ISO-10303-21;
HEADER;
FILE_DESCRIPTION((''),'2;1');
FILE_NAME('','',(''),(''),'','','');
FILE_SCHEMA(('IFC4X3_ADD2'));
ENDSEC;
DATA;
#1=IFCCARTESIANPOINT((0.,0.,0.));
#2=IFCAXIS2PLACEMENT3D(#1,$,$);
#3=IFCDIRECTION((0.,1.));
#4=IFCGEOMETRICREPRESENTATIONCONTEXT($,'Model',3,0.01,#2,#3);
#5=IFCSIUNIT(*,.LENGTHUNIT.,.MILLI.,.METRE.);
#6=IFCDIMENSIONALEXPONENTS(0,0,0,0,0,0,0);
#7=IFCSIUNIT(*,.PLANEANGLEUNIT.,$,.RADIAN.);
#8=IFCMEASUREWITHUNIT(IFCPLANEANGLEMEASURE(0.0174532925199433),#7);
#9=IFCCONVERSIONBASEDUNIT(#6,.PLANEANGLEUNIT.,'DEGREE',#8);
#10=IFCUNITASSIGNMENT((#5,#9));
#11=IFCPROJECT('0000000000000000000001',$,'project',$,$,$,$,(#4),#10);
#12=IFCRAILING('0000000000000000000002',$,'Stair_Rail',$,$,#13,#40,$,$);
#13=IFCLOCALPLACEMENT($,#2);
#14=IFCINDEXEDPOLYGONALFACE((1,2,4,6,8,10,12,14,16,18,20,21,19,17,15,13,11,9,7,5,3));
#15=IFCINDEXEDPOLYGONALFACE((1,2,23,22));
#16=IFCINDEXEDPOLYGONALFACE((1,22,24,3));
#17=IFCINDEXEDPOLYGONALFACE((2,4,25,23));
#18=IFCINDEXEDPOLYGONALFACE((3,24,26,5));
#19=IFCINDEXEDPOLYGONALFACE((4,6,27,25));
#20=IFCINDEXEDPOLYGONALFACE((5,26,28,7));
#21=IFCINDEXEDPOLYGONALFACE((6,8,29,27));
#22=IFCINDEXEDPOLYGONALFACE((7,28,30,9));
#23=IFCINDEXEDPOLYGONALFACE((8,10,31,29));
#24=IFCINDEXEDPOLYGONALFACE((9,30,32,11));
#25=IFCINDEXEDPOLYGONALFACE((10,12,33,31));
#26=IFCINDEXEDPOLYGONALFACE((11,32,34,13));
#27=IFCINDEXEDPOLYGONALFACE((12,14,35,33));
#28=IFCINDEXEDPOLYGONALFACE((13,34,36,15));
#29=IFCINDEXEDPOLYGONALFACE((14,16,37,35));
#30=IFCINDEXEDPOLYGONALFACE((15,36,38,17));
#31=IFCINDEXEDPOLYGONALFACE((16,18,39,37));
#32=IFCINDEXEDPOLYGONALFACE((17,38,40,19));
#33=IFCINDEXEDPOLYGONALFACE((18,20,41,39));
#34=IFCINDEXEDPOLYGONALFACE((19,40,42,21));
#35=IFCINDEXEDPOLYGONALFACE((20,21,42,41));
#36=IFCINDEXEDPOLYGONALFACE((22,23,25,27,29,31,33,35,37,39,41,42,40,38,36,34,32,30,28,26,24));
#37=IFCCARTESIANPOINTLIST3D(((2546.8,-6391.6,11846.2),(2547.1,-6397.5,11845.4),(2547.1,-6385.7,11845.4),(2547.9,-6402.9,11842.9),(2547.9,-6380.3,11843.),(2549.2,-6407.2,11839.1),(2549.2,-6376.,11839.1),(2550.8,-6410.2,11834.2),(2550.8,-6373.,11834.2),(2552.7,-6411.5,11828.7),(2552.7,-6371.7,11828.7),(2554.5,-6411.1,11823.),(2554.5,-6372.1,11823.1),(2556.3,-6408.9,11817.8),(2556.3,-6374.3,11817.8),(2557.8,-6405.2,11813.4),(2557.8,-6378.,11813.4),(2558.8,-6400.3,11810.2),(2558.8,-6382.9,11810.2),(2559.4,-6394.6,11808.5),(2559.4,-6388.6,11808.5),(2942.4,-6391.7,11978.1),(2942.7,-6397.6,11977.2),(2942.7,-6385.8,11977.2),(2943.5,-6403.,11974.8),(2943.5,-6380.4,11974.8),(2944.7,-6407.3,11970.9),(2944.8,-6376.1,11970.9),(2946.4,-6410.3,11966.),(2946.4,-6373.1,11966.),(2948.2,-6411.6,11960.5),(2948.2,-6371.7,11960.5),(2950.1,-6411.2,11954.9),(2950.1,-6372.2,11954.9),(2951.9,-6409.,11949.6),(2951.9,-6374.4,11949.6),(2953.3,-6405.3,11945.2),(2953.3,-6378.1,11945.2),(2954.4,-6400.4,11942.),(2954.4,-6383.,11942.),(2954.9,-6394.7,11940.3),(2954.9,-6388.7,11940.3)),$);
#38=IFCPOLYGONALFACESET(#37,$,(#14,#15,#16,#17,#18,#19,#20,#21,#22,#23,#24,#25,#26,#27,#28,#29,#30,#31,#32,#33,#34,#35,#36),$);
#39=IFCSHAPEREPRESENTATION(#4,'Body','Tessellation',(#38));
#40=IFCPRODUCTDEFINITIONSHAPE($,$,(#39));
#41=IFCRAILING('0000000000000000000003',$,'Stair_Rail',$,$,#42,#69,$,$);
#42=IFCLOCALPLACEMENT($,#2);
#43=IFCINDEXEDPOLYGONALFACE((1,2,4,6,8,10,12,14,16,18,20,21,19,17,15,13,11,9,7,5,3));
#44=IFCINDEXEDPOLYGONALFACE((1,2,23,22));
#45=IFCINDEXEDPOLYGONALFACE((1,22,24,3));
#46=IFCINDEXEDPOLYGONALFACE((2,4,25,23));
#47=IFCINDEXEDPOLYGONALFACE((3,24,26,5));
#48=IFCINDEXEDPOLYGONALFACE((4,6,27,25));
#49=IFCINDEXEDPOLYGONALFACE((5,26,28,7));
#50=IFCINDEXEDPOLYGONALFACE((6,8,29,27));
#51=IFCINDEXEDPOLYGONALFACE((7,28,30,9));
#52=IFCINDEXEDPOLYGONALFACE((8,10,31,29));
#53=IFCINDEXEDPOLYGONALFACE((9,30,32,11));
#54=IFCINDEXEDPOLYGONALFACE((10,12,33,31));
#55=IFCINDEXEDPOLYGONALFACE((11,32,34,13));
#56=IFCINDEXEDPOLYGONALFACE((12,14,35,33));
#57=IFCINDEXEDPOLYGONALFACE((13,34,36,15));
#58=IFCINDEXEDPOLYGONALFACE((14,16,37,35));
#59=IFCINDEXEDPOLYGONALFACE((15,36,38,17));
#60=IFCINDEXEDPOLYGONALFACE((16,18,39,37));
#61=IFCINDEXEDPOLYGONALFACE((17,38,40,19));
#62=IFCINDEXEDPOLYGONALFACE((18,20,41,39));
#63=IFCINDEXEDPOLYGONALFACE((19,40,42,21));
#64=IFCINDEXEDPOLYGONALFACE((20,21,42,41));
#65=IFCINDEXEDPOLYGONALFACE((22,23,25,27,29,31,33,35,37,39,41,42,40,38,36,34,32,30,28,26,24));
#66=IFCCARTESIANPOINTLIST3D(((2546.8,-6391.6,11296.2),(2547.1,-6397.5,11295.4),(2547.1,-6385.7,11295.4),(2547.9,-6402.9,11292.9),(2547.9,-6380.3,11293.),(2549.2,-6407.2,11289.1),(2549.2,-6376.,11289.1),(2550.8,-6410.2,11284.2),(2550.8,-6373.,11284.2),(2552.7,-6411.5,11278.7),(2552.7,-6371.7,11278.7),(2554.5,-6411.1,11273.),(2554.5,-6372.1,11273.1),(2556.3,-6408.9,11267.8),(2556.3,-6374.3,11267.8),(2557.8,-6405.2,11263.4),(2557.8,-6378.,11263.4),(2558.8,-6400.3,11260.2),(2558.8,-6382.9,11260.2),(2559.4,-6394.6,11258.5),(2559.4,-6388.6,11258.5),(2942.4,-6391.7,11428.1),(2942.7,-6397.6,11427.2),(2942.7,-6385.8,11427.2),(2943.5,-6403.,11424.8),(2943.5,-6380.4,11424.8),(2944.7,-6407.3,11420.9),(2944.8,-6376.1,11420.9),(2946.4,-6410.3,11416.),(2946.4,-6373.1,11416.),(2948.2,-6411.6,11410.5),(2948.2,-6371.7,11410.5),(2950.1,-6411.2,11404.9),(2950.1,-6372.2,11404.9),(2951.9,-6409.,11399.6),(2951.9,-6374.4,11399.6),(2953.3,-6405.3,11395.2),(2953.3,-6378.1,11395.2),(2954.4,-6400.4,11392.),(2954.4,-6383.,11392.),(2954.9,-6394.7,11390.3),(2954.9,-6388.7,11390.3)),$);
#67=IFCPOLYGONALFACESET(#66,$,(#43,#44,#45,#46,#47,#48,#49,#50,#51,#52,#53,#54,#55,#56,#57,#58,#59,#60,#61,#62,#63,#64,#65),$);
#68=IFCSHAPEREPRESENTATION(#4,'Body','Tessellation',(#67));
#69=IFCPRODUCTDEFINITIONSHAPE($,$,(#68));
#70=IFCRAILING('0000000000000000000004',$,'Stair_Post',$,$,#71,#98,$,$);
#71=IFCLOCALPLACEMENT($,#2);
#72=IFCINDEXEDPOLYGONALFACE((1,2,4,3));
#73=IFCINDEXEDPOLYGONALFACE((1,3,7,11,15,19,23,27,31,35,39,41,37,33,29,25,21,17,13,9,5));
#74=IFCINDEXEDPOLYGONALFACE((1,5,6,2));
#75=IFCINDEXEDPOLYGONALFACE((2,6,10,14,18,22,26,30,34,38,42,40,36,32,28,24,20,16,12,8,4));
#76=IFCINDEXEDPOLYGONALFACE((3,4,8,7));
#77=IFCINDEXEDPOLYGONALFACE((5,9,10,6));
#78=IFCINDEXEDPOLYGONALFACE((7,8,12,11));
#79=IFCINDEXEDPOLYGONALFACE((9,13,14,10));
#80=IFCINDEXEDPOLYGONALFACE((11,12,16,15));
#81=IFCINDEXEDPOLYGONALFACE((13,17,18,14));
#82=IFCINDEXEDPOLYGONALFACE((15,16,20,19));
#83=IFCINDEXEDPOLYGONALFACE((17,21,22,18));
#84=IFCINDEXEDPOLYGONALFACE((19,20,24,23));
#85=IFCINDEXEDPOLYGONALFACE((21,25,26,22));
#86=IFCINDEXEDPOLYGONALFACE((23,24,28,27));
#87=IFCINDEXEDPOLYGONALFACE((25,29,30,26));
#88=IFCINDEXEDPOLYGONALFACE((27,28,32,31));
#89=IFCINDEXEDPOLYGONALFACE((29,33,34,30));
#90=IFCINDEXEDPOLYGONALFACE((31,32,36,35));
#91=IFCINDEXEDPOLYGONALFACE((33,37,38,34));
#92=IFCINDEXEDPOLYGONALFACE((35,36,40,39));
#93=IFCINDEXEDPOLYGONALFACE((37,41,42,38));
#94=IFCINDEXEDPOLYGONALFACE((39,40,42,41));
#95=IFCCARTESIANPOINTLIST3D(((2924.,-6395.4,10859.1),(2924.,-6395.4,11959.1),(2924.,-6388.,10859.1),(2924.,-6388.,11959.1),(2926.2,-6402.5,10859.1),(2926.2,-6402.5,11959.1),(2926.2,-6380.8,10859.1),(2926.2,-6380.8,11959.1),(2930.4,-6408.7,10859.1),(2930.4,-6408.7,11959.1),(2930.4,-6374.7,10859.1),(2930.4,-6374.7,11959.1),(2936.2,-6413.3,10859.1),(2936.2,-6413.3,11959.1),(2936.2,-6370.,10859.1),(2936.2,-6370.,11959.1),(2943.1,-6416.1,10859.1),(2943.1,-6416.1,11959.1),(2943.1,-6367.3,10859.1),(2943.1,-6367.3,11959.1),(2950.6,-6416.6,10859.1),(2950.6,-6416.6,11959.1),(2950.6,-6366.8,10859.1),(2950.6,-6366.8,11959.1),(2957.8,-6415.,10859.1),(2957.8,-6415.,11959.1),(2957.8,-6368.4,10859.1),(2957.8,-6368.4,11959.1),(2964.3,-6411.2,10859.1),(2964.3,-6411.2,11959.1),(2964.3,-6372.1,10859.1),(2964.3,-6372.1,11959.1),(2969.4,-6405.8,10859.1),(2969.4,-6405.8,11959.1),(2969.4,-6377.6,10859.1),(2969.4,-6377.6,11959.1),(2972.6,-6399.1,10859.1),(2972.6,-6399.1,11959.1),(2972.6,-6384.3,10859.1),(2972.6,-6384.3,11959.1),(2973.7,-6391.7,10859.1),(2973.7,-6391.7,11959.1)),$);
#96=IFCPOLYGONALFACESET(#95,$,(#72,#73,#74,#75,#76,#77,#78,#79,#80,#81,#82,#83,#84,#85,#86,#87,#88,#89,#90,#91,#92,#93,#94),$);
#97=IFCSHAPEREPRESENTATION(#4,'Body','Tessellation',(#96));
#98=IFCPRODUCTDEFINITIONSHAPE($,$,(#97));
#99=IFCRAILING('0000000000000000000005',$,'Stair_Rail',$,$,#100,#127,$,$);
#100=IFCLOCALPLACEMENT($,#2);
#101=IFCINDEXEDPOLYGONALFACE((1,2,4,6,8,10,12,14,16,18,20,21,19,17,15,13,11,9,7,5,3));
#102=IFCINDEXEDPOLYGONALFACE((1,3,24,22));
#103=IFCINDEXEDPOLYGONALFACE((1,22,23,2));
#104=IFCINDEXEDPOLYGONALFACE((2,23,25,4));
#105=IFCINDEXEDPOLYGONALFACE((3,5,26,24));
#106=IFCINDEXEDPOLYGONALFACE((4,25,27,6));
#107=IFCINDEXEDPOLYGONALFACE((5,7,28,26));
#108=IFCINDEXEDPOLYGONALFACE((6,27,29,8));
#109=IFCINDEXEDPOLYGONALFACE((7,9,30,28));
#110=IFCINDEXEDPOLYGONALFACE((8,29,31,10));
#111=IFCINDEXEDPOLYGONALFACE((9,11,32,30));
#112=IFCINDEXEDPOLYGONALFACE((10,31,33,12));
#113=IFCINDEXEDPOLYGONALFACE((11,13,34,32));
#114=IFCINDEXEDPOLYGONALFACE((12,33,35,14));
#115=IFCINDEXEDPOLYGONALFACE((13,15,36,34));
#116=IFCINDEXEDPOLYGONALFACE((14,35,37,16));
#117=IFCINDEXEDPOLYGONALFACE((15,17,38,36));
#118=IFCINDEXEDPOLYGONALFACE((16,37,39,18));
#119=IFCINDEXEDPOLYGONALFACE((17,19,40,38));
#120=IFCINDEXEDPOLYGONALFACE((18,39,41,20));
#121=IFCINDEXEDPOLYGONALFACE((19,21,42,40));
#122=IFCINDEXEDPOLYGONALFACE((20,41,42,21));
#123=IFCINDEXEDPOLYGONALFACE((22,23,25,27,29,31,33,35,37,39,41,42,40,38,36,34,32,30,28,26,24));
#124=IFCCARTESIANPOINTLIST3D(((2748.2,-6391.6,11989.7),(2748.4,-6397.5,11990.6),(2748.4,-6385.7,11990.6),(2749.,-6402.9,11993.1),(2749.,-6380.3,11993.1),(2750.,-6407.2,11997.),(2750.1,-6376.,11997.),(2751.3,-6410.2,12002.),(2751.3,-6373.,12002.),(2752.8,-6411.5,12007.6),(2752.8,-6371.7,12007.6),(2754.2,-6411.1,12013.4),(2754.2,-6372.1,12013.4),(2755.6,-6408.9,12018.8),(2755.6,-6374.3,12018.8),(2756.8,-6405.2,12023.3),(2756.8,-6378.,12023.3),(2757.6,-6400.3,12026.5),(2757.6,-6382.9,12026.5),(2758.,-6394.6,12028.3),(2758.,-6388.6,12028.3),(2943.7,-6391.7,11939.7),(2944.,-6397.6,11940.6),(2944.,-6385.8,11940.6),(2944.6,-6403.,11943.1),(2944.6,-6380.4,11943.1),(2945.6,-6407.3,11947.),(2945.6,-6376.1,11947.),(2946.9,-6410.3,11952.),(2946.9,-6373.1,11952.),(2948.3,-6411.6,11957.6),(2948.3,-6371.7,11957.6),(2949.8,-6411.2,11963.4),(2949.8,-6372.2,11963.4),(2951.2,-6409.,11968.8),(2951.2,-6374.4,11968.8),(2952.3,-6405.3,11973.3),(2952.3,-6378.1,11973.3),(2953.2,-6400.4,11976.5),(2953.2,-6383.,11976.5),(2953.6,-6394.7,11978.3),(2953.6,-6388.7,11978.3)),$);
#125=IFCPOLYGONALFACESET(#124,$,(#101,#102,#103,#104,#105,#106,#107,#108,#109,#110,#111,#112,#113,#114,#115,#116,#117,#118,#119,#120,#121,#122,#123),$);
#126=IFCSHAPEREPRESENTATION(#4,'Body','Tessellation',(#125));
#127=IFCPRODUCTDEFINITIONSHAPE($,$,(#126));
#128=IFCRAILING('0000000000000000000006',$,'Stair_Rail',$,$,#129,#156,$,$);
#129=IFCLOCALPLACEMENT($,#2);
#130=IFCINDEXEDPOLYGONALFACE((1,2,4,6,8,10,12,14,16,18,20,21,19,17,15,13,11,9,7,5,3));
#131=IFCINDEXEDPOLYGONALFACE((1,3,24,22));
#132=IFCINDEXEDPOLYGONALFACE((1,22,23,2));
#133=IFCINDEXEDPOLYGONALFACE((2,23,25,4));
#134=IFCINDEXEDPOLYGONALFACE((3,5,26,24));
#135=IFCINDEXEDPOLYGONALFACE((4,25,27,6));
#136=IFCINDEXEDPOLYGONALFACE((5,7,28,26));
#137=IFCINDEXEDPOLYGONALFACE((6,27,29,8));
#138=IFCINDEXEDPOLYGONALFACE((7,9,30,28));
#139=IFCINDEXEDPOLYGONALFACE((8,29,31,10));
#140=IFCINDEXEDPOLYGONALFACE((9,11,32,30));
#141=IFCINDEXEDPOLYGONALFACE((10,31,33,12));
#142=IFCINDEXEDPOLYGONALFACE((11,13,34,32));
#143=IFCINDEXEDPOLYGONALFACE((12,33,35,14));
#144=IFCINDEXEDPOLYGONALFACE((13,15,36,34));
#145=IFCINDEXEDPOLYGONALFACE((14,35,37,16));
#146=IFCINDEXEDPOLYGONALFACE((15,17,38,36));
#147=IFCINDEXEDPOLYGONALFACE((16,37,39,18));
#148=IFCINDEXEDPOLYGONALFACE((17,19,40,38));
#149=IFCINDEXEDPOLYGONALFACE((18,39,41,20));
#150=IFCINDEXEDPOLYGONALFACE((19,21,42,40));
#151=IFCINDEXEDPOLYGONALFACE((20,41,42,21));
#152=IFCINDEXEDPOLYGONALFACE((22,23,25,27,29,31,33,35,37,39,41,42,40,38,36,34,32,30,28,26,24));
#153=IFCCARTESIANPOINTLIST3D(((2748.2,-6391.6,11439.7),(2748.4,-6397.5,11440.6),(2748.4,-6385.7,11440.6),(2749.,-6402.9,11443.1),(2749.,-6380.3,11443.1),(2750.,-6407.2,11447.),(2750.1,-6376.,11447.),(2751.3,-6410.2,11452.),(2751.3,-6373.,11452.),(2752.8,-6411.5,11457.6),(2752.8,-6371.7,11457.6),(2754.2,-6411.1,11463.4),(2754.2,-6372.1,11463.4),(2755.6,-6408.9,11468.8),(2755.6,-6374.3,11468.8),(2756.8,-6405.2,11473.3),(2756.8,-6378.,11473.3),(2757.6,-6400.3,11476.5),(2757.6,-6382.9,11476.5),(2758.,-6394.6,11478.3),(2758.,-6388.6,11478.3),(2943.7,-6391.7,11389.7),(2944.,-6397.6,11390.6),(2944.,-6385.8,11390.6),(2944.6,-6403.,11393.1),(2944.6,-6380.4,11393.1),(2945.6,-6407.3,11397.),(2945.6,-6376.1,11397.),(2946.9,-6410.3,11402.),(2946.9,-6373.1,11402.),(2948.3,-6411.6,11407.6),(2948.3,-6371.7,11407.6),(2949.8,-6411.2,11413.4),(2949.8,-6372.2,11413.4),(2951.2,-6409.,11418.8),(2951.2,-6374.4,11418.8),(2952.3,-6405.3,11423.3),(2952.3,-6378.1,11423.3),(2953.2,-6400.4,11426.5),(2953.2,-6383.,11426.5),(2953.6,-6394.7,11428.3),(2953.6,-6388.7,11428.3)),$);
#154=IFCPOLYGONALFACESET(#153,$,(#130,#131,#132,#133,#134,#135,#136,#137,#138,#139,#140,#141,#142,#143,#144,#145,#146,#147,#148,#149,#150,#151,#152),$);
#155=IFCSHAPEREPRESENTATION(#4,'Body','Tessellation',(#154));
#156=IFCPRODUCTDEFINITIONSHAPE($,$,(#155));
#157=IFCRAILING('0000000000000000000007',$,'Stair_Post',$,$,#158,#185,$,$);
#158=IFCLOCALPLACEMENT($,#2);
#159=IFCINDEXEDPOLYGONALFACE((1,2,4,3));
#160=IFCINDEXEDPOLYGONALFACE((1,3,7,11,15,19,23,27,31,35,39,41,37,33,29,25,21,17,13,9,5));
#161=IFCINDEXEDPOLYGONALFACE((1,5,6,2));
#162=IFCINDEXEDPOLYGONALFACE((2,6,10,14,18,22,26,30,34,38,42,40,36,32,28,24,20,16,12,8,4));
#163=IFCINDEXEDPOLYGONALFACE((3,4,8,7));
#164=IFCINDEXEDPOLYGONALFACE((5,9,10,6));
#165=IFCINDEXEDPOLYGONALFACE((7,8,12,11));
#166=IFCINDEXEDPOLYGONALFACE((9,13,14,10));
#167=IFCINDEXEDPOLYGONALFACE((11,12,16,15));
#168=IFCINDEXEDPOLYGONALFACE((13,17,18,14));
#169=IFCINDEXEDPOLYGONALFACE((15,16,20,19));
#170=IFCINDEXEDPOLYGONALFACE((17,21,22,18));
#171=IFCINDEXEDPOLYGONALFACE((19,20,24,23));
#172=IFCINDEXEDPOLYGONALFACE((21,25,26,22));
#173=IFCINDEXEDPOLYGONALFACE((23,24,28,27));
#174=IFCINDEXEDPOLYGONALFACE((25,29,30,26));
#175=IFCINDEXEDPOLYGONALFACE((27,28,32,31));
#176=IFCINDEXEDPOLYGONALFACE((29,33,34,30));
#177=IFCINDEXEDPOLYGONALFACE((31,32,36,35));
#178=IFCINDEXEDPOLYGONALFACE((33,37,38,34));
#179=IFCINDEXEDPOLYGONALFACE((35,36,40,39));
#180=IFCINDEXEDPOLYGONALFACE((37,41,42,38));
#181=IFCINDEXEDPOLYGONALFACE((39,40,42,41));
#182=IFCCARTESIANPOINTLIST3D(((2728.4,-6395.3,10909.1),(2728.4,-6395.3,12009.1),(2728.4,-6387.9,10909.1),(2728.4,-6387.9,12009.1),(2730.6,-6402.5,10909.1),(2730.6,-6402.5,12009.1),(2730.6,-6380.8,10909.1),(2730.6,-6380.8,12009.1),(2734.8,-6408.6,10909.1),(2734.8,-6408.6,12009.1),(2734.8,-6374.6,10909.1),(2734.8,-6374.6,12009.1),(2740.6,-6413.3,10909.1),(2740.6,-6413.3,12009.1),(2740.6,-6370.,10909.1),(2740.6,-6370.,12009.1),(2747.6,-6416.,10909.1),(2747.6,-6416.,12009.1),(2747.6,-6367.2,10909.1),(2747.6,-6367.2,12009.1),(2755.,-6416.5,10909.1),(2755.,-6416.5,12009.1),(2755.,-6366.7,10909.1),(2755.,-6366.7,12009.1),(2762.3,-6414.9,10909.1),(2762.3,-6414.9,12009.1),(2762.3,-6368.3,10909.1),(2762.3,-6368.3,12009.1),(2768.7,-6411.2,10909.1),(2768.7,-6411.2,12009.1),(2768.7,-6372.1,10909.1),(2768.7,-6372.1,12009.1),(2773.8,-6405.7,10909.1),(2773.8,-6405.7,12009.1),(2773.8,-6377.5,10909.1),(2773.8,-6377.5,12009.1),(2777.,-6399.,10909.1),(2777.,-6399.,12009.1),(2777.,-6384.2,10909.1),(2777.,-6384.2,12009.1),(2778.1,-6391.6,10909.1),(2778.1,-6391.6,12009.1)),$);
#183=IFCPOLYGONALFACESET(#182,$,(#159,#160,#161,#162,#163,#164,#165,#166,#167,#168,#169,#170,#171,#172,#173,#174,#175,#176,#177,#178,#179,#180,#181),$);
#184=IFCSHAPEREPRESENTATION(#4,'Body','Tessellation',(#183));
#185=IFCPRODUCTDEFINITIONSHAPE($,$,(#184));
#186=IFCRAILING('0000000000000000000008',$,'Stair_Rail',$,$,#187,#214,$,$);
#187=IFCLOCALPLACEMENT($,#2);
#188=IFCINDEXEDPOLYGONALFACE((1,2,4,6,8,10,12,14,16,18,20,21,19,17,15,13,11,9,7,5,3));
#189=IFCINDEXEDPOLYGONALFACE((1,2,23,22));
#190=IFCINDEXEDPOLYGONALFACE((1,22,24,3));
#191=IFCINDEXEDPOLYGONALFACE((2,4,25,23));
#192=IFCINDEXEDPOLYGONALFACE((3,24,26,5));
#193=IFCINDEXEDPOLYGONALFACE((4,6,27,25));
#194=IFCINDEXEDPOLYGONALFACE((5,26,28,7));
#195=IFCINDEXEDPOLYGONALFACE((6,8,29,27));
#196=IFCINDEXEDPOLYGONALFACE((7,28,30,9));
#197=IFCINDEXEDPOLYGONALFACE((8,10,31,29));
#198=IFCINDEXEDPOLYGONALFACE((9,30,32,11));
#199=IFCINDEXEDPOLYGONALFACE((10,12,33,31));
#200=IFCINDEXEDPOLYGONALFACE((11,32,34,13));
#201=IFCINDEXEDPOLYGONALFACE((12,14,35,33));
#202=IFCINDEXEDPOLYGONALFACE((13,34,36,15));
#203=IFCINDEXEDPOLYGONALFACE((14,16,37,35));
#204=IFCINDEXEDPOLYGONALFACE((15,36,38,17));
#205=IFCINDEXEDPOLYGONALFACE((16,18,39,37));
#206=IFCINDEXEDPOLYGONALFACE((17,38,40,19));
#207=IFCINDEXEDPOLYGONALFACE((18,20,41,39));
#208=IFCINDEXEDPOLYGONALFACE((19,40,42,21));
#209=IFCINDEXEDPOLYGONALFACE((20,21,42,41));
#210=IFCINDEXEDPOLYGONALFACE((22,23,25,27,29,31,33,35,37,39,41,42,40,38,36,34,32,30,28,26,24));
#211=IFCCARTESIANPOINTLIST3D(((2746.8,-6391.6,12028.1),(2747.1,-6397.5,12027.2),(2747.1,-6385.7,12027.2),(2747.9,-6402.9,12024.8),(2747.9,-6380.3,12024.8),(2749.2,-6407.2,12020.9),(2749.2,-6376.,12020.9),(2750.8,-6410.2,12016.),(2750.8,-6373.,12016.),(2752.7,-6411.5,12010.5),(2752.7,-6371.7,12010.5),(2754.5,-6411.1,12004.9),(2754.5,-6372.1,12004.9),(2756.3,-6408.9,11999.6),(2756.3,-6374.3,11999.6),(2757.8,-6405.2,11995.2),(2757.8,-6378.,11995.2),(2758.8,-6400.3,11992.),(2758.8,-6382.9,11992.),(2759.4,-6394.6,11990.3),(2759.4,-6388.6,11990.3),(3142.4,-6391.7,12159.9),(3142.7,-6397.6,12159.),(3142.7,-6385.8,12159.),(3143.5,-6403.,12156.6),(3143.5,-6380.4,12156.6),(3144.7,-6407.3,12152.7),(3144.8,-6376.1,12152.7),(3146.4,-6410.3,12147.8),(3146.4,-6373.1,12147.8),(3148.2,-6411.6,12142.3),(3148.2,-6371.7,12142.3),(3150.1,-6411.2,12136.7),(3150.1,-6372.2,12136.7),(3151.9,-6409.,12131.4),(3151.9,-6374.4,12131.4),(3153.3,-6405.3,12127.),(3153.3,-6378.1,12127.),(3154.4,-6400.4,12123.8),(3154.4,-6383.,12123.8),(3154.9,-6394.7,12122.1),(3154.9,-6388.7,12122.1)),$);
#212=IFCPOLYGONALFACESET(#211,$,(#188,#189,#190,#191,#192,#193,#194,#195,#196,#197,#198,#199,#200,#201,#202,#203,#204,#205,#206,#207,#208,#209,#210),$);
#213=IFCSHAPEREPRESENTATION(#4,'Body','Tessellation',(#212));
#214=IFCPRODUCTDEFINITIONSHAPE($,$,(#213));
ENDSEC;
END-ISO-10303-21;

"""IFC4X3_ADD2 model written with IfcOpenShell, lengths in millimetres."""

from ifc_helpers import new_model, entity, si_unit, converted_unit, direction, frame, origin, context, project, circle, extrude, element, save


model = new_model("IFC4X3_ADD2")

# Units and contexts
model_context = context("Model", 3, precision=0.01, world=origin(), true_north=direction((0.0, 1.0)))
ifc_project = project(units=[si_unit("LENGTHUNIT", "METRE", prefix="MILLI"), converted_unit("PLANEANGLEUNIT", "DEGREE", entity("IfcPlaneAngleMeasure", 0.0174532925199433), si_unit("PLANEANGLEUNIT", "RADIAN"), dimensions=[0, 0, 0, 0, 0, 0, 0])], contexts=[model_context])

# Railings
element("IfcRailing", 1, Name="Stair_Rail", context=model_context, shape_type="SweptSolid", body=[
    entity("IfcSweptDiskSolid", entity("IfcPolyline", [entity("IfcCartesianPoint", [2553.1, -6391.6, 11827.3]), entity("IfcCartesianPoint", [2948.7, -6391.7, 11959.1])]), 20.0),
])
element("IfcRailing", 2, Name="Stair_Rail", context=model_context, shape_type="SweptSolid", body=[
    entity("IfcSweptDiskSolid", entity("IfcPolyline", [entity("IfcCartesianPoint", [2553.1, -6391.6, 11277.3]), entity("IfcCartesianPoint", [2948.7, -6391.7, 11409.1])]), 20.0),
])
element("IfcRailing", 3, Name="Stair_Post", context=model_context, shape_type="SweptSolid", body=[
    extrude(circle(Radius=25.0), frame((2948.7, -6391.7, 10859.1)), (0.0, 0.0, 1.0), 1100.0),
])
element("IfcRailing", 4, Name="Stair_Rail", context=model_context, shape_type="SweptSolid", body=[
    entity("IfcSweptDiskSolid", entity("IfcPolyline", [entity("IfcCartesianPoint", [2948.7, -6391.7, 11959.1]), entity("IfcCartesianPoint", [2753.1, -6391.6, 12009.1])]), 20.0),
])
element("IfcRailing", 5, Name="Stair_Rail", context=model_context, shape_type="SweptSolid", body=[
    entity("IfcSweptDiskSolid", entity("IfcPolyline", [entity("IfcCartesianPoint", [2948.7, -6391.7, 11409.1]), entity("IfcCartesianPoint", [2753.1, -6391.6, 11459.1])]), 20.0),
])
element("IfcRailing", 6, Name="Stair_Post", context=model_context, shape_type="SweptSolid", body=[
    extrude(circle(Radius=25.0), frame((2753.1, -6391.6, 10909.1)), (0.0, 0.0, 1.0), 1100.0),
])
element("IfcRailing", 7, Name="Stair_Rail", context=model_context, shape_type="SweptSolid", body=[
    entity("IfcSweptDiskSolid", entity("IfcPolyline", [entity("IfcCartesianPoint", [2753.1, -6391.6, 12009.1]), entity("IfcCartesianPoint", [3148.7, -6391.7, 12140.9])]), 20.0),
])

save(model, "model.ifc")
